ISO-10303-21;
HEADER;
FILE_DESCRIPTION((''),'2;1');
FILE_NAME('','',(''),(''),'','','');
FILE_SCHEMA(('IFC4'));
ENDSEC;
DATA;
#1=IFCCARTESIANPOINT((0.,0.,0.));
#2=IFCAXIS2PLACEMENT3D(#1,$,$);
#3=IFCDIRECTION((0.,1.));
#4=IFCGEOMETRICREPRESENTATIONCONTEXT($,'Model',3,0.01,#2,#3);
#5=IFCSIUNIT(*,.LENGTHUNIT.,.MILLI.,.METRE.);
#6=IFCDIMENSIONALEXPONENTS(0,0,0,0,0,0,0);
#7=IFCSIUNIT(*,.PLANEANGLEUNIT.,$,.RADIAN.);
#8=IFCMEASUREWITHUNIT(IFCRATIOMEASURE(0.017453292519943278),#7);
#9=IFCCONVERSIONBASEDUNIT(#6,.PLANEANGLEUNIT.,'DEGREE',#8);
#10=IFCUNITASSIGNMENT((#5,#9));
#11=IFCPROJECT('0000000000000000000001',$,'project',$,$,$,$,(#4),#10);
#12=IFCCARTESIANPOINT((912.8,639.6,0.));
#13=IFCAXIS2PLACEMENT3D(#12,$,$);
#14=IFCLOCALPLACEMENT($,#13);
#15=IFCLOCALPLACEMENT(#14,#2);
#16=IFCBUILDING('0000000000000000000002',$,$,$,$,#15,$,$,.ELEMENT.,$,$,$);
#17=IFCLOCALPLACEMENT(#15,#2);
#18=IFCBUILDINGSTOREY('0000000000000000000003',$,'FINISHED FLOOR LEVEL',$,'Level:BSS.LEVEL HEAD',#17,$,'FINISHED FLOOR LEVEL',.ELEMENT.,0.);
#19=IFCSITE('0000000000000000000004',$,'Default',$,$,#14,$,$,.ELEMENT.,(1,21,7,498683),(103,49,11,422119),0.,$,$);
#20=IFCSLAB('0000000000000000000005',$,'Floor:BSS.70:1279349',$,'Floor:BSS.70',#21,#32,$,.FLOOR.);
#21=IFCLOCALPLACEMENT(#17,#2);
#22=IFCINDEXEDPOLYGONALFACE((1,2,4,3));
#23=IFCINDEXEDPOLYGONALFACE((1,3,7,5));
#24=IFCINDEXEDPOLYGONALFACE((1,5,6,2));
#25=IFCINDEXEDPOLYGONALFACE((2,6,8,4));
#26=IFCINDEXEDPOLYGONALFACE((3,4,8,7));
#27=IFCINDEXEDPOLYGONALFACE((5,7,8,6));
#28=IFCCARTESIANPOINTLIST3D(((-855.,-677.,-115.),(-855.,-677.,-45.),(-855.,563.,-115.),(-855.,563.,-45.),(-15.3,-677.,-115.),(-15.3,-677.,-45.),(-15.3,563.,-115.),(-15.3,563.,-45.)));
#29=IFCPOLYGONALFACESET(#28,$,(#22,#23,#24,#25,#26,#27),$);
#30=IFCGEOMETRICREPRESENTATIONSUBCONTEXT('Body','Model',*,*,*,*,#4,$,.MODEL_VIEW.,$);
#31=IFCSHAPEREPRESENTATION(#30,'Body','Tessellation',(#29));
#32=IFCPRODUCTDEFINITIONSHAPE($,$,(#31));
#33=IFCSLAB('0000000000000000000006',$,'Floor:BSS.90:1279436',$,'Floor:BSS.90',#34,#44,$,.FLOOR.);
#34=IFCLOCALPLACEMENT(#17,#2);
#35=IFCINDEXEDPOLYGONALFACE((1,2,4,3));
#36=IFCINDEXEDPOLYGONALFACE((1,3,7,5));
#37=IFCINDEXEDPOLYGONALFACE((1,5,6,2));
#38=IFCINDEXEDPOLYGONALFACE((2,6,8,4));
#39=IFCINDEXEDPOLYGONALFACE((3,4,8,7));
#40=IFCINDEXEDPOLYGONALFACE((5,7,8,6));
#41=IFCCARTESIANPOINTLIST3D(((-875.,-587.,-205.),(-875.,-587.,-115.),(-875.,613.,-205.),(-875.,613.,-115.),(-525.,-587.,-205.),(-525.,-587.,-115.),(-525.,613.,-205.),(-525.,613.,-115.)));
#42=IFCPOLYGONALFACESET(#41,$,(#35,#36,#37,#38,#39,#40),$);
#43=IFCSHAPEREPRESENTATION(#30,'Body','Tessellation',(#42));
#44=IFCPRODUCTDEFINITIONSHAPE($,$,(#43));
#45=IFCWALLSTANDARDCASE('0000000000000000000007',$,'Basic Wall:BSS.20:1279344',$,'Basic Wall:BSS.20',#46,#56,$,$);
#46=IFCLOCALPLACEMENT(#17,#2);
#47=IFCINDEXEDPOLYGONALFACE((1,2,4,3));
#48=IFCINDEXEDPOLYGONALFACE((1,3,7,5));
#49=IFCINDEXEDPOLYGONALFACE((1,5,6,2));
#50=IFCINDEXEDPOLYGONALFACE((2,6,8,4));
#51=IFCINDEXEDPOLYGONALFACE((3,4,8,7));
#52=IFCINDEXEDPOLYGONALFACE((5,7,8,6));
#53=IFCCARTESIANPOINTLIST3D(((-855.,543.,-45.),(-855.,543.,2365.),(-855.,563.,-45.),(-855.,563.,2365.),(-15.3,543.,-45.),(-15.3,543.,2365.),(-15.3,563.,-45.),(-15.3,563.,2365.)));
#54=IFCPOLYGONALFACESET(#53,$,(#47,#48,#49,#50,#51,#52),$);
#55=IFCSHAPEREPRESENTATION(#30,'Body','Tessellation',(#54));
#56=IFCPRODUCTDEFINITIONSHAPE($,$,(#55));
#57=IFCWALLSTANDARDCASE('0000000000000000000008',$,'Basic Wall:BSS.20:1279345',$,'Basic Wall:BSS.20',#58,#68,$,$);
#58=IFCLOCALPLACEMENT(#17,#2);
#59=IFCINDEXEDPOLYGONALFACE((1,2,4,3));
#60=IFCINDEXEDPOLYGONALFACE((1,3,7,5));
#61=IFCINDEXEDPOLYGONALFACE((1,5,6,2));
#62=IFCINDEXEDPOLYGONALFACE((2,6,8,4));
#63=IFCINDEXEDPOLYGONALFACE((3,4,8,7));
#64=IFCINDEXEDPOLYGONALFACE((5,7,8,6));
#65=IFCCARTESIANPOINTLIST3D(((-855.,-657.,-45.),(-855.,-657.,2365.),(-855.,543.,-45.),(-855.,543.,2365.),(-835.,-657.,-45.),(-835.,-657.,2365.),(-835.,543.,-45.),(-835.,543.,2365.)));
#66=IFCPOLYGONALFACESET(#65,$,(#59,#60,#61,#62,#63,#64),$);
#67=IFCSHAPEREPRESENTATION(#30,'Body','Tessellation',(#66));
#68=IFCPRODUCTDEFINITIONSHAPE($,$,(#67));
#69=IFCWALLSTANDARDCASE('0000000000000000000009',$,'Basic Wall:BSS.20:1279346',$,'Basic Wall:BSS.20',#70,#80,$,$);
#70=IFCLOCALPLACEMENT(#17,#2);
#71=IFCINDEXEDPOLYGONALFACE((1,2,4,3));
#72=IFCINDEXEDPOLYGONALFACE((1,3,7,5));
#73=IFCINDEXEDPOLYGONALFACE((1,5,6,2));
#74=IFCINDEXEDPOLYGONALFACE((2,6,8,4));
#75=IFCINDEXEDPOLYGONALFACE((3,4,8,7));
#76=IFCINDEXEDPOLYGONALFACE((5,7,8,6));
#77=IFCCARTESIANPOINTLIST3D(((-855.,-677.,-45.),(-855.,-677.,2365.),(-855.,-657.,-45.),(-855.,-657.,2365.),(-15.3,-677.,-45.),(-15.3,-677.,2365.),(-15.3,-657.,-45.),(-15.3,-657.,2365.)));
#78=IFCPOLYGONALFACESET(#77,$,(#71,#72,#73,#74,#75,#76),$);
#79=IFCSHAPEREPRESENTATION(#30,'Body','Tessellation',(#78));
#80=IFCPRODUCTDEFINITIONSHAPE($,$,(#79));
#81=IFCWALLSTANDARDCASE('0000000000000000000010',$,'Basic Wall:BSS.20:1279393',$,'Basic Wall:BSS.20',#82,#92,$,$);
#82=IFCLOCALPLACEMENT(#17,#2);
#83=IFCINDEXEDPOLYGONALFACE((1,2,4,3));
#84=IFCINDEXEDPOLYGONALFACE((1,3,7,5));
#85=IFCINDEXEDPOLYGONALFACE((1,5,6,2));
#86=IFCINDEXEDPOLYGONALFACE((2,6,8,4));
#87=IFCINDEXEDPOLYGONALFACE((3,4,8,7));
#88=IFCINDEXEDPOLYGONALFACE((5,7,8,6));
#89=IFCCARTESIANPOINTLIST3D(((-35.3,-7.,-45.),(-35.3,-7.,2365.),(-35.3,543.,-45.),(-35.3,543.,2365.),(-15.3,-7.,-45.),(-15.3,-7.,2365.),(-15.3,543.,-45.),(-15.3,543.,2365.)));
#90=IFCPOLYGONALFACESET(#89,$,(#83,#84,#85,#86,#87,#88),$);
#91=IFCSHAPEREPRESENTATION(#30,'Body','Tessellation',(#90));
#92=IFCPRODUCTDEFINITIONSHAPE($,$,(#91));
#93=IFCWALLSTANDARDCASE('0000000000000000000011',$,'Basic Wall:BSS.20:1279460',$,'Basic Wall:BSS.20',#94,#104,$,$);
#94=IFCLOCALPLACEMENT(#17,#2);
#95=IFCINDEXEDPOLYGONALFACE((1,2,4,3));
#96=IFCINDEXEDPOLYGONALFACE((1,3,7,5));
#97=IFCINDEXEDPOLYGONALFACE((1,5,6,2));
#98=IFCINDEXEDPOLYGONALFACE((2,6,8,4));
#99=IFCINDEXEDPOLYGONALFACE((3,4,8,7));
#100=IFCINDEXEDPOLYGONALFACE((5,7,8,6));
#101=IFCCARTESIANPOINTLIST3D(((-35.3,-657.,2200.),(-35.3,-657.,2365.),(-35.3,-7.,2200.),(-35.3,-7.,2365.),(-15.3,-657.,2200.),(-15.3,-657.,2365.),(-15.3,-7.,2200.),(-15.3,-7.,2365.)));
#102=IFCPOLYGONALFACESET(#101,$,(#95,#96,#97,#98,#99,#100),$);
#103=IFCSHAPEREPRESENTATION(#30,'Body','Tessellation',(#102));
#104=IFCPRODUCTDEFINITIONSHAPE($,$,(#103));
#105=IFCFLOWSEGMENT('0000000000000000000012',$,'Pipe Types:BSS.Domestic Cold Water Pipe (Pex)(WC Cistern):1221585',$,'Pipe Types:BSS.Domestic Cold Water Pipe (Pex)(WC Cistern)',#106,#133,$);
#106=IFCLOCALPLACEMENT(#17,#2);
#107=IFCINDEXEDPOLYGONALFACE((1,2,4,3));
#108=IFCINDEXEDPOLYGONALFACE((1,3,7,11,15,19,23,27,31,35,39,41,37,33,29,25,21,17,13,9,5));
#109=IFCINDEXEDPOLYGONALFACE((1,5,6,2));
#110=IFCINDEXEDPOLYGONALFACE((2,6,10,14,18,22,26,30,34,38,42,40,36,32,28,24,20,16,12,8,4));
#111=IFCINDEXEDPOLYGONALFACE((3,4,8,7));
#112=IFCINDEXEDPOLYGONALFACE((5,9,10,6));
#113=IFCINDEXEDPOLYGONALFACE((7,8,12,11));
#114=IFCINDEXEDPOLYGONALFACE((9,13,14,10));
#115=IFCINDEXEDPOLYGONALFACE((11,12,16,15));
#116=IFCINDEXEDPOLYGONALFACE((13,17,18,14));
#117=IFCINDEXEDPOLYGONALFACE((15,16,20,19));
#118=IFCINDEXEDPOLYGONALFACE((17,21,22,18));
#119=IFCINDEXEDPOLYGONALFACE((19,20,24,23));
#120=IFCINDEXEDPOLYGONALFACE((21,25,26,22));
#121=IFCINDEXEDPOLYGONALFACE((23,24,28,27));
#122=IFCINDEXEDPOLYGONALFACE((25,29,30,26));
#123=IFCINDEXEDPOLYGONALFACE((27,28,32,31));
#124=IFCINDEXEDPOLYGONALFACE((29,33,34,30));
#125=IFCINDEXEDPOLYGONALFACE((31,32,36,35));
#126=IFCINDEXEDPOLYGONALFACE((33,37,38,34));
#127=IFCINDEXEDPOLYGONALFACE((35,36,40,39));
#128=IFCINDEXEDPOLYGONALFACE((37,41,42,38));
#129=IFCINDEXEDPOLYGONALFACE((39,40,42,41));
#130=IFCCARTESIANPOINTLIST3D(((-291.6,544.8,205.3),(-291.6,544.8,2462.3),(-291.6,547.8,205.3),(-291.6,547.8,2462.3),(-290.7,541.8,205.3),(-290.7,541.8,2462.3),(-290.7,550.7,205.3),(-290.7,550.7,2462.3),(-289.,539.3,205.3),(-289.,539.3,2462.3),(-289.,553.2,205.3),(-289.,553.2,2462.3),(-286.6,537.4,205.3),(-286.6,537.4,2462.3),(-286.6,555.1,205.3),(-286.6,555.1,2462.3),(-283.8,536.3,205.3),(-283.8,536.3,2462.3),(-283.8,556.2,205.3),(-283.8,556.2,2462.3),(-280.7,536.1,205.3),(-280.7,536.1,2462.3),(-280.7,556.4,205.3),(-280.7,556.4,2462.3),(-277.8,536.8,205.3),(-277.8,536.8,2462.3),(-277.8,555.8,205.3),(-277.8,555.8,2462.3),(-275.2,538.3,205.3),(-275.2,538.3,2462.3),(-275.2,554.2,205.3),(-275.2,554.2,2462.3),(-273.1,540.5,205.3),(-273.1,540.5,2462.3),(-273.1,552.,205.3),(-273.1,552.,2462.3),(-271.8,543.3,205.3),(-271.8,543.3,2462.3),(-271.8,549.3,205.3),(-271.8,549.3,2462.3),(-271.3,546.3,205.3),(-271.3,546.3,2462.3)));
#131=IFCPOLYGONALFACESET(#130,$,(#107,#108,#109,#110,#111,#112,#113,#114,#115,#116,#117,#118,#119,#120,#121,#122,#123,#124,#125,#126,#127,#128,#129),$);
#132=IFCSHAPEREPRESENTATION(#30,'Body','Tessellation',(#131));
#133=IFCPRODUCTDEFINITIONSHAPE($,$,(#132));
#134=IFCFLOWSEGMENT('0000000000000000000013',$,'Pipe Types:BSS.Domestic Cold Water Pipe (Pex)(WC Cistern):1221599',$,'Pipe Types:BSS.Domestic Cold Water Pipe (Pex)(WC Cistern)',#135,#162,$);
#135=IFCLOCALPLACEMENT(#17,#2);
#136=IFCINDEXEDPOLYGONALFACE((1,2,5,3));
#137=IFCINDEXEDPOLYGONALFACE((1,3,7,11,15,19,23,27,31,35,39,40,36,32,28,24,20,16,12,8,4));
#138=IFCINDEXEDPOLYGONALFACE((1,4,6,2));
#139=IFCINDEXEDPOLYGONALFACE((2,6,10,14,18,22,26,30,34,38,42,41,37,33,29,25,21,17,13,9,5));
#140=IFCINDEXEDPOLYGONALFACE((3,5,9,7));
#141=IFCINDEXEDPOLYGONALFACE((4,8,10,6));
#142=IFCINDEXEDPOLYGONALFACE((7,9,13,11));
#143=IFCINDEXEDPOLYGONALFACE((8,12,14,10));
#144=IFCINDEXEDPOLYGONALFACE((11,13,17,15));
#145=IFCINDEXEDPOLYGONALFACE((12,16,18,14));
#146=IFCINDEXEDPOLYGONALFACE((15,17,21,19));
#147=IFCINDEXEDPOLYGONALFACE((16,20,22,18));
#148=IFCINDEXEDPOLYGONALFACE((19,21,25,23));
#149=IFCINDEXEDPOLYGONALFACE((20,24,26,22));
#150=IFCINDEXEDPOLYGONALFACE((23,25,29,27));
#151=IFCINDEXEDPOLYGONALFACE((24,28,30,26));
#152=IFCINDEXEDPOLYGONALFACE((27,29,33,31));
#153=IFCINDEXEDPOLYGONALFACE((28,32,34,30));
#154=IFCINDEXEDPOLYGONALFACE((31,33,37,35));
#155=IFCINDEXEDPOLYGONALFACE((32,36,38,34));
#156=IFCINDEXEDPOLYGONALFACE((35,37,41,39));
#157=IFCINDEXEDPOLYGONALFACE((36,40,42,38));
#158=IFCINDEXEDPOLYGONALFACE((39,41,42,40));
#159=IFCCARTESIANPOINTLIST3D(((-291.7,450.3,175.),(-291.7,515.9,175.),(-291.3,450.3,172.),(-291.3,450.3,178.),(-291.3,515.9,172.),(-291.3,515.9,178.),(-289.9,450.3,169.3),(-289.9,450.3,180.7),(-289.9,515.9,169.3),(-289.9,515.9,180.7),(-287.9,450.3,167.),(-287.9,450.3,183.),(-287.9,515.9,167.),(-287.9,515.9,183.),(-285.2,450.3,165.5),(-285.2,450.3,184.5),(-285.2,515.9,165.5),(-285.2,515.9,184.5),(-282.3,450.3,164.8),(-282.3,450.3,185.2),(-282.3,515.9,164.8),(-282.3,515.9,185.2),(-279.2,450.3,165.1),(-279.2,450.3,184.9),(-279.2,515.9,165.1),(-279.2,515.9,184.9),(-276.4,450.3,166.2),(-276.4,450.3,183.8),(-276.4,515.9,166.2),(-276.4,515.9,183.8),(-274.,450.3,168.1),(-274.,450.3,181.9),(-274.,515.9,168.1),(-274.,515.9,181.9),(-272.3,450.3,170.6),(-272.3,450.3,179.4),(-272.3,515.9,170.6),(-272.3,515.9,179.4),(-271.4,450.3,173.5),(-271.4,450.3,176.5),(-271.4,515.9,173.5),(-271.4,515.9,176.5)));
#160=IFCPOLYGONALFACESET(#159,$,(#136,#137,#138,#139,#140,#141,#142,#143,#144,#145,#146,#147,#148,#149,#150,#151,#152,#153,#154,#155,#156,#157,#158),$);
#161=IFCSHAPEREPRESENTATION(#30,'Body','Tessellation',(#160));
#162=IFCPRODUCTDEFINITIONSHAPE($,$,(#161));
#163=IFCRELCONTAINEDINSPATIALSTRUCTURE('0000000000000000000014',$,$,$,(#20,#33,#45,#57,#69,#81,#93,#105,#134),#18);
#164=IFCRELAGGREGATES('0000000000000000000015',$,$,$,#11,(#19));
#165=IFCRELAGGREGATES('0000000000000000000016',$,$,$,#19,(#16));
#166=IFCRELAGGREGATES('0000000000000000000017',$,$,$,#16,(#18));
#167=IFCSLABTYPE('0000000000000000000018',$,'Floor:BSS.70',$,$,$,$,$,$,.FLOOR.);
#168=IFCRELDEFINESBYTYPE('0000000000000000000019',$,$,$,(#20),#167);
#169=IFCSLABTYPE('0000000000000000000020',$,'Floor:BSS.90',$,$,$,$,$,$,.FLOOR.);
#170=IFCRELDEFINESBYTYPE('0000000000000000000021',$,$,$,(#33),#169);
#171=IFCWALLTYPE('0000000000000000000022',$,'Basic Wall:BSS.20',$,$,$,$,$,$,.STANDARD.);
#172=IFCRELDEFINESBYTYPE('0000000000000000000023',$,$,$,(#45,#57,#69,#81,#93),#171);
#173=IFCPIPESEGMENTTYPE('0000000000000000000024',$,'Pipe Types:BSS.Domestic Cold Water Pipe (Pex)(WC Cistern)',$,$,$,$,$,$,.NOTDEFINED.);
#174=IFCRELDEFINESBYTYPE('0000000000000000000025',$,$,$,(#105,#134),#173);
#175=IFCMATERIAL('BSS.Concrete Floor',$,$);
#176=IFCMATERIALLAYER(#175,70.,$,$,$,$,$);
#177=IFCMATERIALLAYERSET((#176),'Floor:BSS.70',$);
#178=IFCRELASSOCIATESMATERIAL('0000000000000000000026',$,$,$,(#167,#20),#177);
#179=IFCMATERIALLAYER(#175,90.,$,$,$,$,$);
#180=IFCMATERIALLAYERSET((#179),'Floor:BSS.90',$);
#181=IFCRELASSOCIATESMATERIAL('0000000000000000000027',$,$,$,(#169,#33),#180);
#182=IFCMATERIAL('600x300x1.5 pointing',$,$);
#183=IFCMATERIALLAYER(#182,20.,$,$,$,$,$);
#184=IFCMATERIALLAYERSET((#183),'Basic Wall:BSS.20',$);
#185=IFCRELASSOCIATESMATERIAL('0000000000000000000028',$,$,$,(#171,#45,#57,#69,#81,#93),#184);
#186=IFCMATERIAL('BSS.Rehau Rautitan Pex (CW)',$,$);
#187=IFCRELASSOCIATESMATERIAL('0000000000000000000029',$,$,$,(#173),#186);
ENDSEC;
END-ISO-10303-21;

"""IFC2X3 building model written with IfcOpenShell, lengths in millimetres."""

from ifc_helpers import new_model, entity, si_unit, converted_unit, direction, frame, frame_2d, origin, place, context, subcontext, project, spatial, rectangle, circle, extrude, clip, halfspace, material, layer, layer_set, layer_usage, type_object, element, save


model = new_model("IFC2X3")

# Units and contexts
model_context = context("Model", 3, precision=0.01, world=origin(), true_north=direction((0.0, 1.0)))
body_context = subcontext(model_context, "Body", "Model", "MODEL_VIEW")
ifc_project = project(units=[si_unit("LENGTHUNIT", "METRE", prefix="MILLI"), converted_unit("PLANEANGLEUNIT", "DEGREE", entity("IfcRatioMeasure", 0.017453292519943278), si_unit("PLANEANGLEUNIT", "RADIAN"), dimensions=[0, 0, 0, 0, 0, 0, 0])], contexts=[model_context])

# Site, building, storey
site_placement = place(None, frame((912.8, 639.6, 0.0)))
site = spatial("IfcSite", under=ifc_project, at=site_placement, Name="Default", CompositionType="ELEMENT", RefLatitude=(1, 21, 7, 498683), RefLongitude=(103, 49, 11, 422119), RefElevation=0.0)
building_placement = place(site_placement, origin())
building = spatial("IfcBuilding", under=site, at=building_placement, CompositionType="ELEMENT")
storey_placement = place(building_placement, origin())
storey = spatial("IfcBuildingStorey", under=building, at=storey_placement, Name="FINISHED FLOOR LEVEL", ObjectType="Level:BSS.LEVEL HEAD", LongName="FINISHED FLOOR LEVEL", CompositionType="ELEMENT", Elevation=0.0)

# Slabs
ifc_material_1 = material(Name="BSS.Concrete Floor")
ifc_layer_1 = layer(ifc_material_1, 70.0)
ifc_layer_set_1 = layer_set([ifc_layer_1], Name="Floor:BSS.70")
ifc_layer_usage_1 = layer_usage(ifc_layer_set_1, "AXIS3", "POSITIVE", 0.0)
slab_type_1 = type_object("IfcSlabType", Name="Floor:BSS.70", PredefinedType="FLOOR", material=ifc_layer_set_1)
slab_1_placement = place(storey_placement, origin())
element("IfcSlab", 1, at=slab_1_placement, inside=storey, type_object=slab_type_1, material=ifc_layer_usage_1, Name="Floor:BSS.70:1279349", ObjectType="Floor:BSS.70", PredefinedType="FLOOR", context=body_context, shape_type="SweptSolid", body=[
    extrude(rectangle(XDim=1240.0, YDim=839.7, at=frame_2d((0.0, 0.0), x_axis=(1.0, 0.0))), frame((-435.1, -57.0, -45.0), z_axis=(0.0, 0.0, -1.0), x_axis=(0.0, 1.0, 0.0)), (0.0, 0.0, 1.0), 70.0),
])
ifc_material_2 = material(Name="600x300x1.5 pointing")
ifc_layer_2 = layer(ifc_material_1, 90.0)
ifc_layer_set_2 = layer_set([ifc_layer_2], Name="Floor:BSS.90")
ifc_layer_usage_2 = layer_usage(ifc_layer_set_2, "AXIS3", "POSITIVE", 0.0)
slab_type_2 = type_object("IfcSlabType", Name="Floor:BSS.90", PredefinedType="FLOOR", material=ifc_layer_set_2)
slab_2_placement = place(storey_placement, origin())
element("IfcSlab", 2, at=slab_2_placement, inside=storey, type_object=slab_type_2, material=ifc_layer_usage_2, Name="Floor:BSS.90:1279436", ObjectType="Floor:BSS.90", PredefinedType="FLOOR", context=body_context, shape_type="SweptSolid", body=[
    extrude(rectangle(XDim=1200.0, YDim=350.0, at=frame_2d((0.0, 0.0), x_axis=(1.0, 0.0))), frame((-700.0, 13.0, -115.0), z_axis=(0.0, 0.0, -1.0), x_axis=(0.0, 1.0, 0.0)), (0.0, 0.0, 1.0), 90.0),
])

# Walls
ifc_layer_3 = layer(ifc_material_2, 20.0)
ifc_layer_set_3 = layer_set([ifc_layer_3], Name="Basic Wall:BSS.20")
ifc_layer_usage_3 = layer_usage(ifc_layer_set_3, "AXIS2", "POSITIVE", -10.0)
wall_type_1 = type_object("IfcWallType", Name="Basic Wall:BSS.20", PredefinedType="STANDARD", material=ifc_layer_set_3)
wall_1_placement = place(storey_placement, frame((-15.3, 553.0, -45.0), z_axis=(0.0, 0.0, 1.0), x_axis=(-1.0, 0.0, 0.0)))
element("IfcWallStandardCase", 3, at=wall_1_placement, inside=storey, type_object=wall_type_1, material=ifc_layer_usage_3, Name="Basic Wall:BSS.20:1279344", ObjectType="Basic Wall:BSS.20", context=body_context, shape_type="SweptSolid", body=[
    extrude(rectangle(XDim=839.7, YDim=20.0, at=frame_2d((419.9, 0.0), x_axis=(-1.0, 0.0))), origin(), (0.0, 0.0, 1.0), 2410.0),
])
ifc_layer_usage_4 = layer_usage(ifc_layer_set_3, "AXIS2", "NEGATIVE", 10.0)
wall_2_placement = place(storey_placement, frame((-845.0, -657.0, -45.0), z_axis=(0.0, 0.0, 1.0), x_axis=(0.0, 1.0, 0.0)))
element("IfcWallStandardCase", 4, at=wall_2_placement, inside=storey, type_object=wall_type_1, material=ifc_layer_usage_4, Name="Basic Wall:BSS.20:1279345", ObjectType="Basic Wall:BSS.20", context=body_context, shape_type="SweptSolid", body=[
    extrude(rectangle(XDim=1200.0, YDim=20.0, at=frame_2d((600.0, 0.0), x_axis=(-1.0, 0.0))), origin(), (0.0, 0.0, 1.0), 2410.0),
])
ifc_layer_usage_5 = layer_usage(ifc_layer_set_3, "AXIS2", "POSITIVE", -10.0)
wall_3_placement = place(storey_placement, frame((-855.0, -667.0, -45.0)))
element("IfcWallStandardCase", 5, at=wall_3_placement, inside=storey, type_object=wall_type_1, material=ifc_layer_usage_5, Name="Basic Wall:BSS.20:1279346", ObjectType="Basic Wall:BSS.20", context=body_context, shape_type="SweptSolid", body=[
    extrude(rectangle(XDim=839.7, YDim=20.0, at=frame_2d((419.9, 0.0), x_axis=(-1.0, 0.0))), origin(), (0.0, 0.0, 1.0), 2410.0),
])
ifc_layer_usage_6 = layer_usage(ifc_layer_set_3, "AXIS2", "POSITIVE", -10.0)
wall_4_placement = place(storey_placement, frame((-25.3, -7.0, -45.0), z_axis=(0.0, 0.0, 1.0), x_axis=(0.0, 1.0, 0.0)))
element("IfcWallStandardCase", 6, at=wall_4_placement, inside=storey, type_object=wall_type_1, material=ifc_layer_usage_6, Name="Basic Wall:BSS.20:1279393", ObjectType="Basic Wall:BSS.20", context=body_context, shape_type="SweptSolid", body=[
    extrude(rectangle(XDim=550.0, YDim=20.0, at=frame_2d((275.0, 0.0), x_axis=(-1.0, 0.0))), origin(), (0.0, 0.0, 1.0), 2410.0),
])
ifc_layer_usage_7 = layer_usage(ifc_layer_set_3, "AXIS2", "POSITIVE", -10.0)
wall_5_placement = place(storey_placement, frame((-25.3, -657.0, 2200.0), z_axis=(0.0, 0.0, 1.0), x_axis=(0.0, 1.0, 0.0)))
element("IfcWallStandardCase", 7, at=wall_5_placement, inside=storey, type_object=wall_type_1, material=ifc_layer_usage_7, Name="Basic Wall:BSS.20:1279460", ObjectType="Basic Wall:BSS.20", context=body_context, shape_type="Clipping", body=[
    clip(extrude(rectangle(XDim=650.0, YDim=20.0, at=frame_2d((325.0, 0.0), x_axis=(-1.0, 0.0))), origin(), (0.0, 0.0, 1.0), 165.0), halfspace(frame((650.0, -10.0, 0.0), z_axis=(0.0, 0.0, -1.0), x_axis=(0.0, 1.0, 0.0)), False)),
])

# Flow segments
ifc_material_3 = material(Name="BSS.Rehau Rautitan Pex (CW)")
pipe_segment_type_1 = type_object("IfcPipeSegmentType", Name="Pipe Types:BSS.Domestic Cold Water Pipe (Pex)(WC Cistern)", PredefinedType="NOTDEFINED", material=ifc_material_3)
flow_segment_1_placement = place(storey_placement, origin())
element("IfcFlowSegment", 8, at=flow_segment_1_placement, inside=storey, type_object=pipe_segment_type_1, Name="Pipe Types:BSS.Domestic Cold Water Pipe (Pex)(WC Cistern):1221585", ObjectType="Pipe Types:BSS.Domestic Cold Water Pipe (Pex)(WC Cistern)", context=body_context, shape_type="SweptSolid", body=[
    extrude(circle(Radius=10.2, at=frame_2d((0.0, 0.0), x_axis=(1.0, 0.0))), frame((-281.5, 546.3, 205.3)), (0.0, 0.0, 1.0), 2257.0),
])
flow_segment_2_placement = place(storey_placement, origin())
element("IfcFlowSegment", 9, at=flow_segment_2_placement, inside=storey, type_object=pipe_segment_type_1, Name="Pipe Types:BSS.Domestic Cold Water Pipe (Pex)(WC Cistern):1221599", ObjectType="Pipe Types:BSS.Domestic Cold Water Pipe (Pex)(WC Cistern)", context=body_context, shape_type="SweptSolid", body=[
    extrude(circle(Radius=10.2, at=frame_2d((0.0, 0.0), x_axis=(1.0, 0.0))), frame((-281.5, 450.3, 175.0), z_axis=(0.0, 1.0, 0.0), x_axis=(-1.0, 0.0, 0.0)), (0.0, 0.0, 1.0), 65.6),
])

save(model, "model.ifc")
